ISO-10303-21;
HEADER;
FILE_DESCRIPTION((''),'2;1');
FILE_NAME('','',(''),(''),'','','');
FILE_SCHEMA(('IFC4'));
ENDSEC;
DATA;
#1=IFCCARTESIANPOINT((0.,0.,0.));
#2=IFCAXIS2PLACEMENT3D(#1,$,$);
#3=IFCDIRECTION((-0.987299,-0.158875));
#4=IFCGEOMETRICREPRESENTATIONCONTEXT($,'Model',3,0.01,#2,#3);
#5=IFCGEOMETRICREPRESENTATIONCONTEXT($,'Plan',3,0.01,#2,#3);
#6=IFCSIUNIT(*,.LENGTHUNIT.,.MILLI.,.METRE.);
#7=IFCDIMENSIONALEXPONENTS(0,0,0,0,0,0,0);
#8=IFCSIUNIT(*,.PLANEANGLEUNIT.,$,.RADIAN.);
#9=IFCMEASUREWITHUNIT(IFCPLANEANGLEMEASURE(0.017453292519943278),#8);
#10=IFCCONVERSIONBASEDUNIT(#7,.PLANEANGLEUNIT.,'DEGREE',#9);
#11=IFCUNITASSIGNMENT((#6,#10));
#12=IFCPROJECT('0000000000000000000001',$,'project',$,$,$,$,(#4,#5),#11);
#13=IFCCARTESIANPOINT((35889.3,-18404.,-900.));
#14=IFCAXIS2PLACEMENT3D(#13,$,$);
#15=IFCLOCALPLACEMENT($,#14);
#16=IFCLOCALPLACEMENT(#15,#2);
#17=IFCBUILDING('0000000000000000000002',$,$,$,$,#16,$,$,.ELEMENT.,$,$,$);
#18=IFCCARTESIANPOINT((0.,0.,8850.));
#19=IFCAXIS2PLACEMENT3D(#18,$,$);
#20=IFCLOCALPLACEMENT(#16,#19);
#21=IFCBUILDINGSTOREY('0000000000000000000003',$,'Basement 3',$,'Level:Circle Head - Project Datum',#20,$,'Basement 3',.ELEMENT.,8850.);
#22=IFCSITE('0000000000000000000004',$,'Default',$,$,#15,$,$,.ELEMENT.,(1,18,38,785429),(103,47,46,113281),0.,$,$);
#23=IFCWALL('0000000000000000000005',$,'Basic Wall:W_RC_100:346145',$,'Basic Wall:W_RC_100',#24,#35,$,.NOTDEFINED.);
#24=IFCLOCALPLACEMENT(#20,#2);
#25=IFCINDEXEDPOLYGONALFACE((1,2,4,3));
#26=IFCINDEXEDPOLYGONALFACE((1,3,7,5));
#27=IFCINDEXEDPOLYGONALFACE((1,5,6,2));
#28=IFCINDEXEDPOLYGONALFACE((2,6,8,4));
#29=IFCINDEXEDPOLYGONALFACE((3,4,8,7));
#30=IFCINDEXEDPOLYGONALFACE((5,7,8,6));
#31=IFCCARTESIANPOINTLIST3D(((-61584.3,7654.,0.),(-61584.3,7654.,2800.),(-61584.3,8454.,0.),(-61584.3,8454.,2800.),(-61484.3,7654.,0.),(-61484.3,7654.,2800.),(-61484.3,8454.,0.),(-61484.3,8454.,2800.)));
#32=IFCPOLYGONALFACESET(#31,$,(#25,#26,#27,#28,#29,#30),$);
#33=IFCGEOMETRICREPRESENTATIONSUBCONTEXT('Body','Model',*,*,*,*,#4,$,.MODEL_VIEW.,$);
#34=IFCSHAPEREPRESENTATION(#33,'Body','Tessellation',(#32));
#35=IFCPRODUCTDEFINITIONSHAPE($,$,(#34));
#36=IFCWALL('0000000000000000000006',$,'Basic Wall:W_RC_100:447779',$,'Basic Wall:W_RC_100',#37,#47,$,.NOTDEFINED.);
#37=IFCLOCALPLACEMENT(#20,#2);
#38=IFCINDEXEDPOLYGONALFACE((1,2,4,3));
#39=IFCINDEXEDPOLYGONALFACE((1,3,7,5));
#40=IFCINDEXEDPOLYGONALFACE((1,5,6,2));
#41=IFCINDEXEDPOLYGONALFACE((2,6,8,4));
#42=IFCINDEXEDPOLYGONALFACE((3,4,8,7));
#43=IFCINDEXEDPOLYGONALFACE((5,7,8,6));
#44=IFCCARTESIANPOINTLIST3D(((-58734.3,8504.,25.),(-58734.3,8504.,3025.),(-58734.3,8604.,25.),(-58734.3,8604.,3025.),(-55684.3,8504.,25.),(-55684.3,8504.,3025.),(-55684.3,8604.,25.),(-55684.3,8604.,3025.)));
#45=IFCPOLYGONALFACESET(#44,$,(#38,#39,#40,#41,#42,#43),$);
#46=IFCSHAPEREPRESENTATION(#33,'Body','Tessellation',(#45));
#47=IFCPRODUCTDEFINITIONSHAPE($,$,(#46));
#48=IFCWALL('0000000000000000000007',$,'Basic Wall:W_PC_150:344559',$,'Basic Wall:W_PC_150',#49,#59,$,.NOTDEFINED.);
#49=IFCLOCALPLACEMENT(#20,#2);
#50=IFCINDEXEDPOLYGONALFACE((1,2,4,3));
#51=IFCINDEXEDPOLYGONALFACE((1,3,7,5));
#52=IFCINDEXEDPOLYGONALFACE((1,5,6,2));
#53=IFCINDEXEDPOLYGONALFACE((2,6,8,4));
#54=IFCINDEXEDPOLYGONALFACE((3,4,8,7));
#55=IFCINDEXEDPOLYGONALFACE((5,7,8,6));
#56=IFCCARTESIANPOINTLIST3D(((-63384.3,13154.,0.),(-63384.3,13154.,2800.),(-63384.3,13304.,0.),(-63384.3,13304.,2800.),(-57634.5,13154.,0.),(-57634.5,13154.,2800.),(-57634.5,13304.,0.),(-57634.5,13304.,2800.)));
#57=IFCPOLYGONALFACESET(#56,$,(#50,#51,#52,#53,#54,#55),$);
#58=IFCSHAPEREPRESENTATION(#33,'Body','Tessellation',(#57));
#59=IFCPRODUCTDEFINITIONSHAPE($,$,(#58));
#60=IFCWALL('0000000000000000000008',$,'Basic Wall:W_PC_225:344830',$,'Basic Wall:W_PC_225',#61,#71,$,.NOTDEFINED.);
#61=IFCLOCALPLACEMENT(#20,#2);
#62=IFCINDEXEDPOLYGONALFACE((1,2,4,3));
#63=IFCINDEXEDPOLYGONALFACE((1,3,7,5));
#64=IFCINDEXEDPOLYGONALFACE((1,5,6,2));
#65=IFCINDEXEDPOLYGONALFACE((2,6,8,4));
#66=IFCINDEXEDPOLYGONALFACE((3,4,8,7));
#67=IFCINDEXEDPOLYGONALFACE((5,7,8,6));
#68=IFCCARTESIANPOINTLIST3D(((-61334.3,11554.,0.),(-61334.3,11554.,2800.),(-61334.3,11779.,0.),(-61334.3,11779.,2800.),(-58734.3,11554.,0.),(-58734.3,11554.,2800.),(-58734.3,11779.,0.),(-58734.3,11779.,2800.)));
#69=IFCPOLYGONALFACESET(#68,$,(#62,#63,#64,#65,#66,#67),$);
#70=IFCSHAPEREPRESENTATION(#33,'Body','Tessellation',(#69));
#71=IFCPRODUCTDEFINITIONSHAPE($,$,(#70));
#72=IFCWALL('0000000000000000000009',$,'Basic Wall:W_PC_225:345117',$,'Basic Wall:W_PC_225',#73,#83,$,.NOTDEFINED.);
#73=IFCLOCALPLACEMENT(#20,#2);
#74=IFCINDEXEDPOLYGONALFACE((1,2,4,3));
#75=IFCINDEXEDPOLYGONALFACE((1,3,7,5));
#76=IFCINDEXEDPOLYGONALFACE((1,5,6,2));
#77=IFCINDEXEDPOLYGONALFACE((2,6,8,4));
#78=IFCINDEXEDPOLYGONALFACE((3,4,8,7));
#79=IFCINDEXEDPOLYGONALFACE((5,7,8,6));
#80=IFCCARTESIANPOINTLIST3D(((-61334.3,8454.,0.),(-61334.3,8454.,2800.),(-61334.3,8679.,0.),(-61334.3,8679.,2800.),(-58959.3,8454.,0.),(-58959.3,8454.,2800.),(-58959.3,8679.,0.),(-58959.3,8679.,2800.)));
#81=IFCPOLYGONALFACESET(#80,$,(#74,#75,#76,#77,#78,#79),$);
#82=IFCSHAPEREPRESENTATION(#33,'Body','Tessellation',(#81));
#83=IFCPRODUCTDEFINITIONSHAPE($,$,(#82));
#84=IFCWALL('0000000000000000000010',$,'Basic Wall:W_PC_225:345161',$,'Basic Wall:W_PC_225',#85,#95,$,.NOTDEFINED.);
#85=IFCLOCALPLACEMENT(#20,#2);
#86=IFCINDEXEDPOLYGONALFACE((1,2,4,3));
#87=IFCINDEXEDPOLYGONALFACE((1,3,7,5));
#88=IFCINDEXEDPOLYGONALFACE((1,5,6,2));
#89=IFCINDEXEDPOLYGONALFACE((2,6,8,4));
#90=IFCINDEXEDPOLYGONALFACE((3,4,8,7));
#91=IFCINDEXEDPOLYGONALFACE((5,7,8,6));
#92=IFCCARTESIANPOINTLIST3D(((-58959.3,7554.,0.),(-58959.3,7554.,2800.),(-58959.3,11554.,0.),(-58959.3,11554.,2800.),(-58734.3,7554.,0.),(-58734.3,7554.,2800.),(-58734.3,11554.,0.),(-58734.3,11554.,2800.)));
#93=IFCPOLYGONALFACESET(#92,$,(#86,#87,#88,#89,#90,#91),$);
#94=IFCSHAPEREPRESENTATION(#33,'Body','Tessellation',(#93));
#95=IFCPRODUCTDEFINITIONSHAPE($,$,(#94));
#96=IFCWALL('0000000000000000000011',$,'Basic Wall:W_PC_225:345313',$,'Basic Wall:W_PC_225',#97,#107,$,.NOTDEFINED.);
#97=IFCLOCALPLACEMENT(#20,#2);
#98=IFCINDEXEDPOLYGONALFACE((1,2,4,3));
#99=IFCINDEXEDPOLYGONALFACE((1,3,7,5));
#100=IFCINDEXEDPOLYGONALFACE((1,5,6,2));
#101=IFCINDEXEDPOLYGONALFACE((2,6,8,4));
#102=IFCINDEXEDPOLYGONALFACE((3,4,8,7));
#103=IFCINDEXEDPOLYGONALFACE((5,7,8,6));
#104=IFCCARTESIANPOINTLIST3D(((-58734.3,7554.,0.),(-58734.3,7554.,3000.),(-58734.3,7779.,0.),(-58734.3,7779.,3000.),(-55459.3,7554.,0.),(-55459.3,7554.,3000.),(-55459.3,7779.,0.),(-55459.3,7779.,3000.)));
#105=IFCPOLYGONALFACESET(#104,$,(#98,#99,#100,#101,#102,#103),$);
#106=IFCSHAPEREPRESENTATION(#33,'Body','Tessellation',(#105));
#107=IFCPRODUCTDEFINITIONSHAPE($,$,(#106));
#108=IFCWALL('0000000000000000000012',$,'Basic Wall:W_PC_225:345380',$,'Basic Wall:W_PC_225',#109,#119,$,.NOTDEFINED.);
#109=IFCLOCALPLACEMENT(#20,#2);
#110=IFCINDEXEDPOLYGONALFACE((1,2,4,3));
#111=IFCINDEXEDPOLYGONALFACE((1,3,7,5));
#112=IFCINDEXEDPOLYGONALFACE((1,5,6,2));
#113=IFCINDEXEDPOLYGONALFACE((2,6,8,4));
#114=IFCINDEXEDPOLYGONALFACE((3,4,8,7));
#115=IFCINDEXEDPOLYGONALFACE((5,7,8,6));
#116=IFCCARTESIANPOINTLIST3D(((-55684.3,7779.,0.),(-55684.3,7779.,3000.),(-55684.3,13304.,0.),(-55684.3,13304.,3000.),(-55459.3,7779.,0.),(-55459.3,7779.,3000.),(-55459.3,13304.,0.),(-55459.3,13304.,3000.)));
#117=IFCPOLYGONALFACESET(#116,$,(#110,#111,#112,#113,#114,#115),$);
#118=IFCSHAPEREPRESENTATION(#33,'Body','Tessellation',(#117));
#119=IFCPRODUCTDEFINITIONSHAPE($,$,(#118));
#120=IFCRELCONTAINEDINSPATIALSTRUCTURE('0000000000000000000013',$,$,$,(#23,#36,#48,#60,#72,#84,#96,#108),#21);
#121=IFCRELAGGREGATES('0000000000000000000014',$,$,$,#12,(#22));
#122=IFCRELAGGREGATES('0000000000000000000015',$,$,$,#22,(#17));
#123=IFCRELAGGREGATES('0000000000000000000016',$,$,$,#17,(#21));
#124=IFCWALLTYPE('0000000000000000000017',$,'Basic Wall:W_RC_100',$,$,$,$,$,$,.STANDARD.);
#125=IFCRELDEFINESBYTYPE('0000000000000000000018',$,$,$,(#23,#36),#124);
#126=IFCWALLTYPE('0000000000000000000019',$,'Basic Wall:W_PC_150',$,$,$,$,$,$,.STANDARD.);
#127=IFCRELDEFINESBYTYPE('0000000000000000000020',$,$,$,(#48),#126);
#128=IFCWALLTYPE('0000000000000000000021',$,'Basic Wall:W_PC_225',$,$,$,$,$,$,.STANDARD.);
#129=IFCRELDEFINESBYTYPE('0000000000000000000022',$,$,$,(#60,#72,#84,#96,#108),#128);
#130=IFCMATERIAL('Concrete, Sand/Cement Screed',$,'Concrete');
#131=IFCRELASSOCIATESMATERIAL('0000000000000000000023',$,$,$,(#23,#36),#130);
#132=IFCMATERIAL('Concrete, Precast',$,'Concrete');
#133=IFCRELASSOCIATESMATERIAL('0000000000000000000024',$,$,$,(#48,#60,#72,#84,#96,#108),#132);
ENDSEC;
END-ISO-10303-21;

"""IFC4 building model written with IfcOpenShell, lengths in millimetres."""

from ifc_helpers import new_model, entity, si_unit, converted_unit, direction, frame, origin, place, context, subcontext, project, spatial, indexed_curve, outline, extrude, material, type_object, element, save


model = new_model("IFC4")

# Units and contexts
model_context = context("Model", 3, precision=0.01, world=origin(), true_north=direction((-0.987299, -0.158875)))
plan_context = context("Plan", 3, precision=0.01, world=origin(), true_north=direction((-0.987299, -0.158875)))
body_context = subcontext(model_context, "Body", "Model", "MODEL_VIEW")
ifc_project = project(units=[si_unit("LENGTHUNIT", "METRE", prefix="MILLI"), converted_unit("PLANEANGLEUNIT", "DEGREE", entity("IfcPlaneAngleMeasure", 0.017453292519943278), si_unit("PLANEANGLEUNIT", "RADIAN"), dimensions=[0, 0, 0, 0, 0, 0, 0])], contexts=[model_context, plan_context])

# Site, building, storey
site_placement = place(None, frame((35889.3, -18404.0, -900.0)))
site = spatial("IfcSite", under=ifc_project, at=site_placement, Name="Default", CompositionType="ELEMENT", RefLatitude=(1, 18, 38, 785429), RefLongitude=(103, 47, 46, 113281), RefElevation=0.0)
building_placement = place(site_placement, origin())
building = spatial("IfcBuilding", under=site, at=building_placement, CompositionType="ELEMENT")
storey_placement = place(building_placement, frame((0.0, 0.0, 8850.0)))
storey = spatial("IfcBuildingStorey", under=building, at=storey_placement, Name="Basement 3", ObjectType="Level:Circle Head - Project Datum", LongName="Basement 3", CompositionType="ELEMENT", Elevation=8850.0)

# Shared definitions
ifc_material_1 = material(Name="Concrete, Precast", Category="Concrete")

# Walls
ifc_material_2 = material(Name="Concrete, Sand/Cement Screed", Category="Concrete")
wall_type_1 = type_object("IfcWallType", Name="Basic Wall:W_RC_100", PredefinedType="STANDARD")
wall_1_placement = place(storey_placement, frame((-61534.3, 8454.0, 0.0), z_axis=(0.0, 0.0, 1.0), x_axis=(0.0, -1.0, 0.0)))
element("IfcWall", 1, at=wall_1_placement, inside=storey, type_object=wall_type_1, material=ifc_material_2, Name="Basic Wall:W_RC_100:346145", ObjectType="Basic Wall:W_RC_100", PredefinedType="NOTDEFINED", context=body_context, shape_type="SweptSolid", body=[
    extrude(outline(indexed_curve([(800.0, 50.0), (0.0, 50.0), (0.0, -50.0), (800.0, -50.0), (800.0, 50.0)], self_intersect=False)), origin(), (0.0, 0.0, 1.0), 2800.0),
])
wall_2_placement = place(storey_placement, frame((-58734.3, 8554.0, 25.0)))
element("IfcWall", 2, at=wall_2_placement, inside=storey, type_object=wall_type_1, material=ifc_material_2, Name="Basic Wall:W_RC_100:447779", ObjectType="Basic Wall:W_RC_100", PredefinedType="NOTDEFINED", context=body_context, shape_type="SweptSolid", body=[
    extrude(outline(indexed_curve([(3050.0, 50.0), (0.0, 50.0), (0.0, -50.0), (3050.0, -50.0), (3050.0, 50.0)], self_intersect=False)), origin(), (0.0, 0.0, 1.0), 3000.0),
])
wall_type_2 = type_object("IfcWallType", Name="Basic Wall:W_PC_150", PredefinedType="STANDARD")
wall_3_placement = place(storey_placement, frame((-57634.5, 13229.0, 0.0), z_axis=(0.0, 0.0, 1.0), x_axis=(-1.0, 0.0, 0.0)))
element("IfcWall", 3, at=wall_3_placement, inside=storey, type_object=wall_type_2, material=ifc_material_1, Name="Basic Wall:W_PC_150:344559", ObjectType="Basic Wall:W_PC_150", PredefinedType="NOTDEFINED", context=body_context, shape_type="SweptSolid", body=[
    extrude(outline(indexed_curve([(5749.8, 75.0), (0.0, 75.0), (0.0, -75.0), (5749.8, -75.0), (5749.8, 75.0)], self_intersect=False)), origin(), (0.0, 0.0, 1.0), 2800.0),
])
wall_type_3 = type_object("IfcWallType", Name="Basic Wall:W_PC_225", PredefinedType="STANDARD")
wall_4_placement = place(storey_placement, frame((-61334.3, 11666.5, 0.0)))
element("IfcWall", 4, at=wall_4_placement, inside=storey, type_object=wall_type_3, material=ifc_material_1, Name="Basic Wall:W_PC_225:344830", ObjectType="Basic Wall:W_PC_225", PredefinedType="NOTDEFINED", context=body_context, shape_type="SweptSolid", body=[
    extrude(outline(indexed_curve([(2600.0, 112.5), (0.0, 112.5), (0.0, -112.5), (2600.0, -112.5), (2600.0, 112.5)], self_intersect=False)), origin(), (0.0, 0.0, 1.0), 2800.0),
])
wall_5_placement = place(storey_placement, frame((-61334.3, 8566.5, 0.0)))
element("IfcWall", 5, at=wall_5_placement, inside=storey, type_object=wall_type_3, material=ifc_material_1, Name="Basic Wall:W_PC_225:345117", ObjectType="Basic Wall:W_PC_225", PredefinedType="NOTDEFINED", context=body_context, shape_type="SweptSolid", body=[
    extrude(outline(indexed_curve([(2375.0, 112.5), (0.0, 112.5), (0.0, -112.5), (2375.0, -112.5), (2375.0, 112.5)], self_intersect=False)), origin(), (0.0, 0.0, 1.0), 2800.0),
])
wall_6_placement = place(storey_placement, frame((-58846.8, 7554.0, 0.0), z_axis=(0.0, 0.0, 1.0), x_axis=(0.0, 1.0, 0.0)))
element("IfcWall", 6, at=wall_6_placement, inside=storey, type_object=wall_type_3, material=ifc_material_1, Name="Basic Wall:W_PC_225:345161", ObjectType="Basic Wall:W_PC_225", PredefinedType="NOTDEFINED", context=body_context, shape_type="SweptSolid", body=[
    extrude(outline(indexed_curve([(4000.0, 112.5), (0.0, 112.5), (0.0, -112.5), (4000.0, -112.5), (4000.0, 112.5)], self_intersect=False)), origin(), (0.0, 0.0, 1.0), 2800.0),
])
wall_7_placement = place(storey_placement, frame((-58734.3, 7666.5, 0.0)))
element("IfcWall", 7, at=wall_7_placement, inside=storey, type_object=wall_type_3, material=ifc_material_1, Name="Basic Wall:W_PC_225:345313", ObjectType="Basic Wall:W_PC_225", PredefinedType="NOTDEFINED", context=body_context, shape_type="SweptSolid", body=[
    extrude(outline(indexed_curve([(3275.0, 112.5), (0.0, 112.5), (0.0, -112.5), (3275.0, -112.5), (3275.0, 112.5)], self_intersect=False)), origin(), (0.0, 0.0, 1.0), 3000.0),
])
wall_8_placement = place(storey_placement, frame((-55571.8, 7779.0, 0.0), z_axis=(0.0, 0.0, 1.0), x_axis=(0.0, 1.0, 0.0)))
element("IfcWall", 8, at=wall_8_placement, inside=storey, type_object=wall_type_3, material=ifc_material_1, Name="Basic Wall:W_PC_225:345380", ObjectType="Basic Wall:W_PC_225", PredefinedType="NOTDEFINED", context=body_context, shape_type="SweptSolid", body=[
    extrude(outline(indexed_curve([(5525.0, 112.5), (0.0, 112.5), (0.0, -112.5), (5525.0, -112.5), (5525.0, 112.5)], self_intersect=False)), origin(), (0.0, 0.0, 1.0), 3000.0),
])

save(model, "model.ifc")
